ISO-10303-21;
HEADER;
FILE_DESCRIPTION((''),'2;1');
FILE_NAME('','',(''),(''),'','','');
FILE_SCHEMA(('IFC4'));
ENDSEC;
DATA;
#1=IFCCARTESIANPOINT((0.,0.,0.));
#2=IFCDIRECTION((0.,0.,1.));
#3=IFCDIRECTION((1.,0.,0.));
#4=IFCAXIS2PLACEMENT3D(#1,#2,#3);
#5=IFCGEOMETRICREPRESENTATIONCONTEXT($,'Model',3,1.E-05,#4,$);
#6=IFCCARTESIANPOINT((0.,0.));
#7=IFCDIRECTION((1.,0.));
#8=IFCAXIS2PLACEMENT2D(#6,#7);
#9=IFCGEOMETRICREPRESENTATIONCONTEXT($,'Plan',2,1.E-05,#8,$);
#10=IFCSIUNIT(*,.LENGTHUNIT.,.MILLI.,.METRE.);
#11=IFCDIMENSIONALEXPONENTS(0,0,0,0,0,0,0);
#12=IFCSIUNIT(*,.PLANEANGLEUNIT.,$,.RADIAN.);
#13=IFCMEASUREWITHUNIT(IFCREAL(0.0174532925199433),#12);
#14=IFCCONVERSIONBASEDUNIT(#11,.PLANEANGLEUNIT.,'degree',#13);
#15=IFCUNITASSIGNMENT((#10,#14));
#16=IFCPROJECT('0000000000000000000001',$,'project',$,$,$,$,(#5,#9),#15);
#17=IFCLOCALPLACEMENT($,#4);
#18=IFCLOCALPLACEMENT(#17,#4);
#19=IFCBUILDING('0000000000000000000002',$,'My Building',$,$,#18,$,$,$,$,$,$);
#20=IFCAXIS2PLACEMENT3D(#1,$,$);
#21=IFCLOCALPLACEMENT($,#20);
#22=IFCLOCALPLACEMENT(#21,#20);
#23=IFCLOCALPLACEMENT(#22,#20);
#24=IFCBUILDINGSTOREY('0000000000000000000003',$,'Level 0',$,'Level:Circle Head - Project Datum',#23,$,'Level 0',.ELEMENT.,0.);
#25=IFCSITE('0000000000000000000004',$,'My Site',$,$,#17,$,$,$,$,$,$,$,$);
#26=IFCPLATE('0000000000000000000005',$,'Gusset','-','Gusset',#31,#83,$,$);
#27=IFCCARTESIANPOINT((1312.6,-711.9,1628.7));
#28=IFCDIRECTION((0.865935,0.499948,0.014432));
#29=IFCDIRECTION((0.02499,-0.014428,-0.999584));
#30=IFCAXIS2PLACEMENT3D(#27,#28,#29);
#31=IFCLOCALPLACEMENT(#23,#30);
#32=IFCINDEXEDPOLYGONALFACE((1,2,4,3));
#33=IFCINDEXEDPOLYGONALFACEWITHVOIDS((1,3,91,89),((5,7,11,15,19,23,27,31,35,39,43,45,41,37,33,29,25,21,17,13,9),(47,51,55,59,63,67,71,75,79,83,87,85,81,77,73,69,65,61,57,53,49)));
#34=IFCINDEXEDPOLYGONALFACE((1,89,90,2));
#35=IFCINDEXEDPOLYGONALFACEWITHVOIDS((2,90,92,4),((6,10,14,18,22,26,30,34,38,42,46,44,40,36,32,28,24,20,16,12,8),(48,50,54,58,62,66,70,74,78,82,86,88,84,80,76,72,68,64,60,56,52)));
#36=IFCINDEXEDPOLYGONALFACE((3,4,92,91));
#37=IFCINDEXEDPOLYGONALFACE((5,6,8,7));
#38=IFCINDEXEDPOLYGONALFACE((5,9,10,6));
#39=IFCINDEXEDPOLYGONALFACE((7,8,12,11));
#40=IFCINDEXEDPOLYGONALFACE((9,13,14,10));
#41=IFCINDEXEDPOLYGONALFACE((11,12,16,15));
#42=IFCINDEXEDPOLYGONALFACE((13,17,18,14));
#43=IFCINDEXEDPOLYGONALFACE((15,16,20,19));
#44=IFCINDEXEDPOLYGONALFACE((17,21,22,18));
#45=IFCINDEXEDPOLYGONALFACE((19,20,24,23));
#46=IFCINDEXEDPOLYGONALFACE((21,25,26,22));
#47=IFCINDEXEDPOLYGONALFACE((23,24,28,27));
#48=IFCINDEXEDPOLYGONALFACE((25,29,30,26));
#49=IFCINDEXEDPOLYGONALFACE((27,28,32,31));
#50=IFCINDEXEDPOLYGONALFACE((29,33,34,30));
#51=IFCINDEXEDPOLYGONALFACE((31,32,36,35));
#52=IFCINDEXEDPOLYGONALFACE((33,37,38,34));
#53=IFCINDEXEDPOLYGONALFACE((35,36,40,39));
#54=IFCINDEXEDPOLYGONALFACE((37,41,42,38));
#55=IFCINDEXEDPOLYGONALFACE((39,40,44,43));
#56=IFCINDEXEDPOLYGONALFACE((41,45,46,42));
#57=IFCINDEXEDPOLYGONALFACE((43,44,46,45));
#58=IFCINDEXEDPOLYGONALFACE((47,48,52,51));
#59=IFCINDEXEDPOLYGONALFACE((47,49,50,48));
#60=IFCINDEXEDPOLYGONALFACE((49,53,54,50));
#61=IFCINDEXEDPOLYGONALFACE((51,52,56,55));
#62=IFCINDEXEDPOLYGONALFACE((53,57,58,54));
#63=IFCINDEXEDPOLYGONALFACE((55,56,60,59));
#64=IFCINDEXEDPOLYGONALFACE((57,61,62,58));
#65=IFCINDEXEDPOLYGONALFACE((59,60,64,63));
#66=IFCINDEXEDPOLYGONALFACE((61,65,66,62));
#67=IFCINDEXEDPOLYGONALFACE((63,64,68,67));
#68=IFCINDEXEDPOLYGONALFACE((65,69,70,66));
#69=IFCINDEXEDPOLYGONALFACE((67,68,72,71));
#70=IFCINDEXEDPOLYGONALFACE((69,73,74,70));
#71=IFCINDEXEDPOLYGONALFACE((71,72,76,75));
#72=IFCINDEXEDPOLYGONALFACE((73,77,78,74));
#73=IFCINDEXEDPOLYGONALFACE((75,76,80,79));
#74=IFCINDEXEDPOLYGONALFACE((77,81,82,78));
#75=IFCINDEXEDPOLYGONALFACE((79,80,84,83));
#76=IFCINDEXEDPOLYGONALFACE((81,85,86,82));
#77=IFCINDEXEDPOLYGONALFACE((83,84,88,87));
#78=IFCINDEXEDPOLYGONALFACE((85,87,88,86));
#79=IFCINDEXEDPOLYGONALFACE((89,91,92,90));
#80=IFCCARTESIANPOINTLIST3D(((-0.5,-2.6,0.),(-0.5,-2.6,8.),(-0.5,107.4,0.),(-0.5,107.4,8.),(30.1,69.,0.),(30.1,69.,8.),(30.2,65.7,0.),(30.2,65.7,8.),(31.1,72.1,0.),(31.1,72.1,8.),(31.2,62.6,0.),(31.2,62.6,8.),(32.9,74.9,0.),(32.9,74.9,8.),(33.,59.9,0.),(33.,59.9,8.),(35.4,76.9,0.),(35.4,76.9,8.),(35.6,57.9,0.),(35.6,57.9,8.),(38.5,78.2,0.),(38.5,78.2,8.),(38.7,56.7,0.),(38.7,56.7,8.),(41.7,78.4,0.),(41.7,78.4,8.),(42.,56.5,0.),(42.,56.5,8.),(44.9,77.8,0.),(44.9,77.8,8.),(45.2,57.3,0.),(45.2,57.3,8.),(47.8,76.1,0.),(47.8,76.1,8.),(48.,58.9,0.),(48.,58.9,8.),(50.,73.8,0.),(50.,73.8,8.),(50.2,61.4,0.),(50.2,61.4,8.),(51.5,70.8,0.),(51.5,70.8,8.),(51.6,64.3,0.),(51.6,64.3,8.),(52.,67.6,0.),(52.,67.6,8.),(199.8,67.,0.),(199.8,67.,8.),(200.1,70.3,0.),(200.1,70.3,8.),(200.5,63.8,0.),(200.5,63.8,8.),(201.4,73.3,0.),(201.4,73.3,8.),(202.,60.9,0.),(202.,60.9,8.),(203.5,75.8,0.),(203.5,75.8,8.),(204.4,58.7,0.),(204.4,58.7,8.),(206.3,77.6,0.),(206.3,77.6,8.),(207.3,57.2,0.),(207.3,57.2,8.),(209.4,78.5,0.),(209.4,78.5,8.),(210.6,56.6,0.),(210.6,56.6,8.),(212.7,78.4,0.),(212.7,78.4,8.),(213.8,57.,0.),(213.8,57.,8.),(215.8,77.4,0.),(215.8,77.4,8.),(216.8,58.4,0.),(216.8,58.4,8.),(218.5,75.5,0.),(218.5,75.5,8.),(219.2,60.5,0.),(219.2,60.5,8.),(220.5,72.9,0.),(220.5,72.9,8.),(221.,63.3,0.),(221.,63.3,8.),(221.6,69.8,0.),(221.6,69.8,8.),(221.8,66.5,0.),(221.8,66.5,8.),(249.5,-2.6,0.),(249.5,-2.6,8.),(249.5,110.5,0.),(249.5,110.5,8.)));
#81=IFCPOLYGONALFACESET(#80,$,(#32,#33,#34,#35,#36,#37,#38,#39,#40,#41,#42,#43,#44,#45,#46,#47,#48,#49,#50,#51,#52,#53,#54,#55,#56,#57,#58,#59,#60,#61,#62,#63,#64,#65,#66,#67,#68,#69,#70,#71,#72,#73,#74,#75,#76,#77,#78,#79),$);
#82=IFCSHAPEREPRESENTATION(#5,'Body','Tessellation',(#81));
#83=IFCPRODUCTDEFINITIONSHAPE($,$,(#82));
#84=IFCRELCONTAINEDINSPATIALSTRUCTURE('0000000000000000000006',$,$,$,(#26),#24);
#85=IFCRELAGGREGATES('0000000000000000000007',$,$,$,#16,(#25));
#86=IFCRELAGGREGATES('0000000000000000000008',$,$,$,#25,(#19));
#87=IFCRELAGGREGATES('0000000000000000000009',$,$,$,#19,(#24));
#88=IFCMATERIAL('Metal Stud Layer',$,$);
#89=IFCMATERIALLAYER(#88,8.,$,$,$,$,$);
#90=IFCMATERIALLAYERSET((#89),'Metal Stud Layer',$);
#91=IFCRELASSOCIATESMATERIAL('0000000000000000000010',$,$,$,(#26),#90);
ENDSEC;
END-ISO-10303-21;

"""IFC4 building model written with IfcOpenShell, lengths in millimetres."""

from ifc_helpers import new_model, entity, si_unit, converted_unit, frame, origin, origin_with_axes, origin_2d_with_axis, place, context, project, spatial, polyline, circle, outline, extrude, material, layer, layer_set, element, save


model = new_model("IFC4")

# Units and contexts
model_context = context("Model", 3, precision=1e-05, world=origin_with_axes())
plan_context = context("Plan", 2, precision=1e-05, world=origin_2d_with_axis())
ifc_project = project(units=[si_unit("LENGTHUNIT", "METRE", prefix="MILLI"), converted_unit("PLANEANGLEUNIT", "degree", entity("IfcReal", 0.0174532925199433), si_unit("PLANEANGLEUNIT", "RADIAN"), dimensions=[0, 0, 0, 0, 0, 0, 0])], contexts=[model_context, plan_context])

# Site, building, storey
site_placement = place(None, origin_with_axes())
site = spatial("IfcSite", under=ifc_project, at=site_placement, Name="My Site")
building_placement = place(site_placement, origin_with_axes())
building = spatial("IfcBuilding", under=site, at=building_placement, Name="My Building")
placement_1 = place(None, origin())
placement_2 = place(placement_1, origin())
storey_placement = place(placement_2, origin())
storey = spatial("IfcBuildingStorey", under=building, at=storey_placement, Name="Level 0", ObjectType="Level:Circle Head - Project Datum", LongName="Level 0", CompositionType="ELEMENT", Elevation=0.0)

# Plate, openings
ifc_material = material(Name="Metal Stud Layer")
ifc_layer_1 = layer(ifc_material, 8.0)
ifc_layer_set_1 = layer_set([ifc_layer_1], Name="Metal Stud Layer")
plate_1_placement = place(storey_placement, frame((1312.6, -711.9, 1628.7), z_axis=(0.865935, 0.499948, 0.014432), x_axis=(0.02499, -0.014428, -0.999584)))
plate_1 = element("IfcPlate", 1, at=plate_1_placement, inside=storey, material=ifc_layer_set_1, Name="Gusset", Description="-", ObjectType="Gusset", context=model_context, shape_type="SweptSolid", body=[
    extrude(outline(polyline([(-0.5, -2.6), (249.5, -2.6), (249.5, 110.5), (-0.5, 107.4), (-0.5, -2.6)])), origin_with_axes(), (0.0, 0.0, 1.0), 8.0),
])
opening_1_placement = place(plate_1_placement, frame((41.0, 67.5, 8.5), z_axis=(0.0, 0.0, -1.0), x_axis=(-0.509338, 0.860567, 0.0)))
element("IfcOpeningElement", 2, at=opening_1_placement, cuts=plate_1, ObjectType="Opening", context=model_context, shape_type="SweptSolid", body=[
    extrude(circle(Radius=11.0, at=origin_2d_with_axis()), origin(), (0.0, 0.0, 1.0), 9.0),
])
opening_2_placement = place(plate_1_placement, frame((210.8, 67.6, 8.5), z_axis=(0.0, 0.0, -1.0), x_axis=(0.454822, 0.890582, 0.0)))
element("IfcOpeningElement", 3, at=opening_2_placement, cuts=plate_1, ObjectType="Opening", context=model_context, shape_type="SweptSolid", body=[
    extrude(circle(Radius=11.0, at=origin_2d_with_axis()), origin(), (0.0, 0.0, 1.0), 9.0),
])

save(model, "model.ifc")
